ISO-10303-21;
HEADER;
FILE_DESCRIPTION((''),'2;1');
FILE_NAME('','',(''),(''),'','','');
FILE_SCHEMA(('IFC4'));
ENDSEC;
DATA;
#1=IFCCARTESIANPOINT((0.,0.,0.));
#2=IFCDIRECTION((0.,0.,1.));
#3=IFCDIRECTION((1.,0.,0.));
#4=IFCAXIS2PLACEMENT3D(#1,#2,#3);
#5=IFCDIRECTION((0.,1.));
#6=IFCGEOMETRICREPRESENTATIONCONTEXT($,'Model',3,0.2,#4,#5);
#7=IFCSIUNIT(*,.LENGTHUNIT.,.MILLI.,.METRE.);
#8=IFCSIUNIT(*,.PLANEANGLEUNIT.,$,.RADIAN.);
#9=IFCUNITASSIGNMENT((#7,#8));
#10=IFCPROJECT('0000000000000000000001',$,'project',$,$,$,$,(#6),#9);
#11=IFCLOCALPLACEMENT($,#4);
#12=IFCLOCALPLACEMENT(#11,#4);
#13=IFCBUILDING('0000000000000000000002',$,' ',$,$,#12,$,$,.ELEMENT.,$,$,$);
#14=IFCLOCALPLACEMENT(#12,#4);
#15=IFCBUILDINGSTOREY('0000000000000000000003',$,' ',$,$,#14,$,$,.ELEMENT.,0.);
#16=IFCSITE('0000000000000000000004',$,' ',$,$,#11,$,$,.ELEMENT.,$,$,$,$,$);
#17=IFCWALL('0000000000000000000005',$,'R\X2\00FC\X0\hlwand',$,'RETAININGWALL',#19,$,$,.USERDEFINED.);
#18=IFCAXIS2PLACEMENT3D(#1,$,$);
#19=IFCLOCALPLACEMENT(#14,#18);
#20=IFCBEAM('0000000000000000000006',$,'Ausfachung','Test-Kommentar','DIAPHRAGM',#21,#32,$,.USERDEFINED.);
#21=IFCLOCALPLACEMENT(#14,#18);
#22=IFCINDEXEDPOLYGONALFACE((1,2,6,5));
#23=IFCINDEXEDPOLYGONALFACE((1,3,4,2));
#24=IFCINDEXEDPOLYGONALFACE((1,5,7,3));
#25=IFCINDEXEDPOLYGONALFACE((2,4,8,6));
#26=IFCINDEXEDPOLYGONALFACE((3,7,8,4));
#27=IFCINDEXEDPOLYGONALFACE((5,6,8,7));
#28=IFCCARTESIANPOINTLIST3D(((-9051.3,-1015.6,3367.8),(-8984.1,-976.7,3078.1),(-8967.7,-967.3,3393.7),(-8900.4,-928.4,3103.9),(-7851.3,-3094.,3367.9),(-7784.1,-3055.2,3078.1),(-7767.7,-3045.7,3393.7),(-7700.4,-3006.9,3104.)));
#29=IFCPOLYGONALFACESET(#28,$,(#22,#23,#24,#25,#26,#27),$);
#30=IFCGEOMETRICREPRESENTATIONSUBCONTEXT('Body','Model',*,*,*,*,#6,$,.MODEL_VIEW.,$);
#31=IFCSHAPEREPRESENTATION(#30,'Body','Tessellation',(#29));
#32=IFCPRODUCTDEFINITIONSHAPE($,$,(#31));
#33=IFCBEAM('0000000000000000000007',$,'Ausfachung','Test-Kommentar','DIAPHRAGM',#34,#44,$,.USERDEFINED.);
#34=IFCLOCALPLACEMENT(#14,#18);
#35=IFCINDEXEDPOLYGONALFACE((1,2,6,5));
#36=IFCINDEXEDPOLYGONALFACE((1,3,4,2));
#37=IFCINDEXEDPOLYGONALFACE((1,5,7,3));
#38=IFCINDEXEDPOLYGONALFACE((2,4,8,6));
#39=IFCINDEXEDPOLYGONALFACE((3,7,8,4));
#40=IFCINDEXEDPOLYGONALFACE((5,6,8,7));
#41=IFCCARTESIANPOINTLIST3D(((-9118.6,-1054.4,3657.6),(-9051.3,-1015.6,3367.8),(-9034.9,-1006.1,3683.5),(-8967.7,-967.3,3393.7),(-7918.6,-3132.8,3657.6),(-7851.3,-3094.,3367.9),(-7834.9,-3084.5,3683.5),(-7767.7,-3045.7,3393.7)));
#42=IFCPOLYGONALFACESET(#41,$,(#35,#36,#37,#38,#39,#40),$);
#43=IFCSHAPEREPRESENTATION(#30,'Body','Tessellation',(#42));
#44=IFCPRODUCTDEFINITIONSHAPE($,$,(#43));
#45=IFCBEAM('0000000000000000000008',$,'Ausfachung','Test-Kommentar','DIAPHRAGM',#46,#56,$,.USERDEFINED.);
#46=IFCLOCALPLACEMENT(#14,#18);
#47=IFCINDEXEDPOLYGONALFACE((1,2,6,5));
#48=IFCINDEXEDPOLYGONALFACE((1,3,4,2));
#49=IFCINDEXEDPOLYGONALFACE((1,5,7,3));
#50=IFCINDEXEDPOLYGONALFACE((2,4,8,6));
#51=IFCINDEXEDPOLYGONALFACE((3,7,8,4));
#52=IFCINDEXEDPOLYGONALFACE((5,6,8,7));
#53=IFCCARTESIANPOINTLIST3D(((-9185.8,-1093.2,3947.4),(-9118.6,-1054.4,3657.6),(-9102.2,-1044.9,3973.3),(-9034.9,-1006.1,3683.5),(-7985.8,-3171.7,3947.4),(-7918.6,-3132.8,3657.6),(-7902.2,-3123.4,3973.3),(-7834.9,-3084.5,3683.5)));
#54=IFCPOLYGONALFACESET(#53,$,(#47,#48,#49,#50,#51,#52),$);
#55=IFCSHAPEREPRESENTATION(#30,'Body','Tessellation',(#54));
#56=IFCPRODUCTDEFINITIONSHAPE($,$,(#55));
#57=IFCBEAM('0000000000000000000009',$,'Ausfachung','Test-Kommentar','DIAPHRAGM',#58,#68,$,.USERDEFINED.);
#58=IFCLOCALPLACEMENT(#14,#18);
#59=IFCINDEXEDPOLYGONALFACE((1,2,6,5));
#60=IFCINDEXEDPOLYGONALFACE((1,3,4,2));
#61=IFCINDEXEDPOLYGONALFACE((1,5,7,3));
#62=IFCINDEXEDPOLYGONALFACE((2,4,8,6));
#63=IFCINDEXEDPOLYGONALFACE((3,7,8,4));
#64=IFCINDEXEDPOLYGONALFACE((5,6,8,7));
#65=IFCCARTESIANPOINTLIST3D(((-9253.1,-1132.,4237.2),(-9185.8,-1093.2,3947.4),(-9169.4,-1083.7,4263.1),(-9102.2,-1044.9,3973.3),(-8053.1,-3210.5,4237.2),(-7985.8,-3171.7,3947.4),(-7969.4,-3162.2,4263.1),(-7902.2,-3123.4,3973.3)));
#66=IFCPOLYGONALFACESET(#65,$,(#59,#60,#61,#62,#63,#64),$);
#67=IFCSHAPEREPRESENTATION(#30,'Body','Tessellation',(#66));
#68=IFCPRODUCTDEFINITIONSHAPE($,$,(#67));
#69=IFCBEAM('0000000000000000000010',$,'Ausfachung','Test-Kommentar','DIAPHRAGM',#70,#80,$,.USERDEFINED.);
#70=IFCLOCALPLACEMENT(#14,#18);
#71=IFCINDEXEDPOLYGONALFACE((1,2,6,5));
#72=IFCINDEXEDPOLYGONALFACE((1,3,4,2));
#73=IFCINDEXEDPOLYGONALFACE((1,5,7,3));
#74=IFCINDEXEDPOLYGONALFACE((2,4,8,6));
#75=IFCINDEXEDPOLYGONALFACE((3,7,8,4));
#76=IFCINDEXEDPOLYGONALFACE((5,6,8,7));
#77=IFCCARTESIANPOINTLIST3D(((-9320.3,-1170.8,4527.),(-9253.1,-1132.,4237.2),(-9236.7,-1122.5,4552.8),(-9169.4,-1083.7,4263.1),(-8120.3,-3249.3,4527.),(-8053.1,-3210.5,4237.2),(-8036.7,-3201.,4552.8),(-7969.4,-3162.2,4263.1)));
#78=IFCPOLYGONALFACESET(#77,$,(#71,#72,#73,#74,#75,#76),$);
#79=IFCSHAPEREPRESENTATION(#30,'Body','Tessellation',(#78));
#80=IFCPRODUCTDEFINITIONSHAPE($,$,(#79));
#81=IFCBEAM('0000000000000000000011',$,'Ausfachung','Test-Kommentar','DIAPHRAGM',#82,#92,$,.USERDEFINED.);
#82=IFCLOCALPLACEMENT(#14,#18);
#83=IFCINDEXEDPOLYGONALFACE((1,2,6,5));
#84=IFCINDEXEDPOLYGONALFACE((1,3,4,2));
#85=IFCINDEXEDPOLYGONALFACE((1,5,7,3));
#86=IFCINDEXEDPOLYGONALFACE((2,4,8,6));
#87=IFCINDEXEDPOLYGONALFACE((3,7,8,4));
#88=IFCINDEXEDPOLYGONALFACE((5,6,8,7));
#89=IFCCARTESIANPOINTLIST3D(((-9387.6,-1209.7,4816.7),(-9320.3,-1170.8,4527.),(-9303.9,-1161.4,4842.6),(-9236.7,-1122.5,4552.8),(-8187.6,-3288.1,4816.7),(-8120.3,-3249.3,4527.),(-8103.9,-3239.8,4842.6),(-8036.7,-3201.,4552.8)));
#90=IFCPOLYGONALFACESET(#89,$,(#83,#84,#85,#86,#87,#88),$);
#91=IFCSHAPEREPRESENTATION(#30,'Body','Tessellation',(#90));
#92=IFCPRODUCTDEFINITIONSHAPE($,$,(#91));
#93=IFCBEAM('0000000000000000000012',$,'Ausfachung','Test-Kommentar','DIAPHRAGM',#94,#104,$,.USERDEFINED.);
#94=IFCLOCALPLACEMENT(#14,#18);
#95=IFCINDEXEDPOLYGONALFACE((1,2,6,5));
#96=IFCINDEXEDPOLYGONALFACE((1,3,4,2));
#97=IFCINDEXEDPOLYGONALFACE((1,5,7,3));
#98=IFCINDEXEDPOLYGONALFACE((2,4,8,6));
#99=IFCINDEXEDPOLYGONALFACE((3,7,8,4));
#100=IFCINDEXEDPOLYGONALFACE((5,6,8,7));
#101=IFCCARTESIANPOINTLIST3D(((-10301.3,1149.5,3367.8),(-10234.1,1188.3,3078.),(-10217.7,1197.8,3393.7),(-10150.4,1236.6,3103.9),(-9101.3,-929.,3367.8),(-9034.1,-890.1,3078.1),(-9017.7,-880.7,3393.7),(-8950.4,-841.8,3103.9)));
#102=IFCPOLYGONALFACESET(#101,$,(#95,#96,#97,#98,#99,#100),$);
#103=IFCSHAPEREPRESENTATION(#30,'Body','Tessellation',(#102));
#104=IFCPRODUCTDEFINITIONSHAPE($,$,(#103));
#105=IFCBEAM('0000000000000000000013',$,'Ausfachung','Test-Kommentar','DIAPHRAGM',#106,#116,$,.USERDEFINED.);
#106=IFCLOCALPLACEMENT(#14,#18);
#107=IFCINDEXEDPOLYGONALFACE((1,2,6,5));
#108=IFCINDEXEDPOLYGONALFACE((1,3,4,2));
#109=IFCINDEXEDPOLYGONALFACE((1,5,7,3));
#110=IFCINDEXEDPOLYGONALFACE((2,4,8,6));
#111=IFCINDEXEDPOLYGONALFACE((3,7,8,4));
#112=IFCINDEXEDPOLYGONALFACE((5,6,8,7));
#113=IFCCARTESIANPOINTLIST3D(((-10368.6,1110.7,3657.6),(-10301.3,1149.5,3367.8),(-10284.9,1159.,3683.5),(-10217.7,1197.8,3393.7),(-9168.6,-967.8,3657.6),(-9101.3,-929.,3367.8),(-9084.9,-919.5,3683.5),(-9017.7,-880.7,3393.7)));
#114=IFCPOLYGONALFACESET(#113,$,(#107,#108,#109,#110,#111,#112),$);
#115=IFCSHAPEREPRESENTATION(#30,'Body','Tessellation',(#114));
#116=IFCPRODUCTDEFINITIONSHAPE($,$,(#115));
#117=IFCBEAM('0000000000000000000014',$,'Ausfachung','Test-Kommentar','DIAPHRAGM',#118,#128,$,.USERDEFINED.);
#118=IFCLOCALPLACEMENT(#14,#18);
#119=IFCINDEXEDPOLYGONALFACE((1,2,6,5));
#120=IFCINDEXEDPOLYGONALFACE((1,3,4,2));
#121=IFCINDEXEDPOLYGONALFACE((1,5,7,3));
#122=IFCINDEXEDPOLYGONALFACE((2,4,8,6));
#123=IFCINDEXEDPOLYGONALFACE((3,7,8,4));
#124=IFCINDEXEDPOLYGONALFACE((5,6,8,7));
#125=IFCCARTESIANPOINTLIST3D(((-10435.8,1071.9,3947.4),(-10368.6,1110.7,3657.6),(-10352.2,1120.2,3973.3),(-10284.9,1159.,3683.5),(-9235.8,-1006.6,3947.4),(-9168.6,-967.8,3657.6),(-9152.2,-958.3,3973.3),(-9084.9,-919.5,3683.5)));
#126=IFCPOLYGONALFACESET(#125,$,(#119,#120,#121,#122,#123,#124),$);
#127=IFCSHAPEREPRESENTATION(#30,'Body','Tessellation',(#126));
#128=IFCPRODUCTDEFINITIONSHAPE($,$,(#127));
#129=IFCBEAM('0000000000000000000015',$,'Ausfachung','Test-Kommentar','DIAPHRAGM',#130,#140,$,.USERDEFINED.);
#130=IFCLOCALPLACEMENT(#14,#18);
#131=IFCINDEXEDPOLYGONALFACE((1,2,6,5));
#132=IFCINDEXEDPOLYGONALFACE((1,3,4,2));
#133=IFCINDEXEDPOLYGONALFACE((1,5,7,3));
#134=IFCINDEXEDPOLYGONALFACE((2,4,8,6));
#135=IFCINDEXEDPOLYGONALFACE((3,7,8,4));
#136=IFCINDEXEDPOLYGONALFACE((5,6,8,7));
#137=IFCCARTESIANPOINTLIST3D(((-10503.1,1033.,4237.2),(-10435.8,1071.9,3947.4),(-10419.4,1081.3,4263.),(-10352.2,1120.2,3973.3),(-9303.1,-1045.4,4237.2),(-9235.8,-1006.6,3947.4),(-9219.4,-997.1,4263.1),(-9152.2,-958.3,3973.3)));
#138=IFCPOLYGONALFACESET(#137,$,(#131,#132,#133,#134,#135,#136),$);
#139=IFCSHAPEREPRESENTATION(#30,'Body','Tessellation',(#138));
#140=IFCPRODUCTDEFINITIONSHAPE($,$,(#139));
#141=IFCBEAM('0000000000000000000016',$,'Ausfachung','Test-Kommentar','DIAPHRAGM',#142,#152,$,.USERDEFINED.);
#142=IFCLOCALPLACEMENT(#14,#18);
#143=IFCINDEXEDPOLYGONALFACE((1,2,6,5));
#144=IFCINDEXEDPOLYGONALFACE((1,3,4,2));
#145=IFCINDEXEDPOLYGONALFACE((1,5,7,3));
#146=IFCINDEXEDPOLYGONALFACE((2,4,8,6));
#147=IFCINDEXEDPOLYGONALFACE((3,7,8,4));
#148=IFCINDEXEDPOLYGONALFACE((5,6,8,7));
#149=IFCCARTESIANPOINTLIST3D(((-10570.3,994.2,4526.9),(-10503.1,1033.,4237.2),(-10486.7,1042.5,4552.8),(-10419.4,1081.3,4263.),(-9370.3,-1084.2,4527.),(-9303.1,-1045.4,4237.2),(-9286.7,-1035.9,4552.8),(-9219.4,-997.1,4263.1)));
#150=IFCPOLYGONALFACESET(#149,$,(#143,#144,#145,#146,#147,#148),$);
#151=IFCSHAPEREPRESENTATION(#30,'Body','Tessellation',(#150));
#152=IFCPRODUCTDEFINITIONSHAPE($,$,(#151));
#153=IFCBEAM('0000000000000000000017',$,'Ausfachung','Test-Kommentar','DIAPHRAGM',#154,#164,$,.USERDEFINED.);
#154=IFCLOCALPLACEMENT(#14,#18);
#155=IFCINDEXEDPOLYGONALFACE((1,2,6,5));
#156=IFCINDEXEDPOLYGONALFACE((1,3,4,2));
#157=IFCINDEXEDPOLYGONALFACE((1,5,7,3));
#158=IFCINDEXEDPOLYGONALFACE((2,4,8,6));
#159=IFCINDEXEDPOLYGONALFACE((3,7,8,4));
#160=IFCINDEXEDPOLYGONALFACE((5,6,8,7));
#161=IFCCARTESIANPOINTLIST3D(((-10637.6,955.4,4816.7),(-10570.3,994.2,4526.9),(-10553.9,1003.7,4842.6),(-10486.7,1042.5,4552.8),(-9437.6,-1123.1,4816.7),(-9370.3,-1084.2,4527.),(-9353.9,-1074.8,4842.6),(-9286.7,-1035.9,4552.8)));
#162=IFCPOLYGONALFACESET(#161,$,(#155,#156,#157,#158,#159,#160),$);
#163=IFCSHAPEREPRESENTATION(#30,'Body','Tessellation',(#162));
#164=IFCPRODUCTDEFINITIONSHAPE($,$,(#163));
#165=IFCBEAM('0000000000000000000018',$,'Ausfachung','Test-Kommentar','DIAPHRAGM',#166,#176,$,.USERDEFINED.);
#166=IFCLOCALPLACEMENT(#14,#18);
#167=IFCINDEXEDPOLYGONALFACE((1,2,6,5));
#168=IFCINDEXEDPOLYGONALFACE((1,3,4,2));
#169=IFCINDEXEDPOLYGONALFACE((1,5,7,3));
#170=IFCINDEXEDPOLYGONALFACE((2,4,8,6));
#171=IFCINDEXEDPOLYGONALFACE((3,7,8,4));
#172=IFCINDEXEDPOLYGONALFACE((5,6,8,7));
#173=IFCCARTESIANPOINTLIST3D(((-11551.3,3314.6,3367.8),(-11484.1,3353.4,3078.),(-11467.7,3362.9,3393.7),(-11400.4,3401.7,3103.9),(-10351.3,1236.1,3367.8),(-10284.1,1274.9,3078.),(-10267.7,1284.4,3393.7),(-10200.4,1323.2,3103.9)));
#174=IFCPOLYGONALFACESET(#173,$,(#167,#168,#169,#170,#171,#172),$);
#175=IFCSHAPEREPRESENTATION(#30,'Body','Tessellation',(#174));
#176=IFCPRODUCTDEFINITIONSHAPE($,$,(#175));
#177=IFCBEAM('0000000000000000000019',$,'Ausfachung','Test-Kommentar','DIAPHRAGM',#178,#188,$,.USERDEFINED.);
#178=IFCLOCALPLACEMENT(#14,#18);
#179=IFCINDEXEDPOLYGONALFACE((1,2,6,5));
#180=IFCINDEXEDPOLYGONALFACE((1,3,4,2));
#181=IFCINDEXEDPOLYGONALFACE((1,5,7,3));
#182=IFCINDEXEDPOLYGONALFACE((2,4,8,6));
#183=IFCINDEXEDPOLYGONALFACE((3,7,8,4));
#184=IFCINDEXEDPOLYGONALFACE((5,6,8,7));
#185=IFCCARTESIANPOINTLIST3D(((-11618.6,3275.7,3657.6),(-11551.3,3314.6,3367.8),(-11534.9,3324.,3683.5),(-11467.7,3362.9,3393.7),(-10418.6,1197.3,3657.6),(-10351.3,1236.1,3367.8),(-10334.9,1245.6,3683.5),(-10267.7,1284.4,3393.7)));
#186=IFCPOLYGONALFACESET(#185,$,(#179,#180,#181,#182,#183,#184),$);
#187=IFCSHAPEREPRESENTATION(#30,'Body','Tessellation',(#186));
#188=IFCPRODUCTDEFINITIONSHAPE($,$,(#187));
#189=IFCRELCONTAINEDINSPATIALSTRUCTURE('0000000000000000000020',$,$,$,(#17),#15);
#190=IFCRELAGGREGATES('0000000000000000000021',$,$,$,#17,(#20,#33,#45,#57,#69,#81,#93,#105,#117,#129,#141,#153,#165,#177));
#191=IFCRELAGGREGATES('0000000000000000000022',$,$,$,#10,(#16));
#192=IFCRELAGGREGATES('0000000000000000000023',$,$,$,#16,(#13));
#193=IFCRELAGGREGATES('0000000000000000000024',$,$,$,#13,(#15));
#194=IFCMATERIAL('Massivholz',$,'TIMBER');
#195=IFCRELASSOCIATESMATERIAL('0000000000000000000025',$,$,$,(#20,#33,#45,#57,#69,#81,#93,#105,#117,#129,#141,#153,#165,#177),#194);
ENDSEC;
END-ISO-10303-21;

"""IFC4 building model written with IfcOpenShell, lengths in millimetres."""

from ifc_helpers import new_model, si_unit, direction, frame, origin_with_axes, place, context, subcontext, project, spatial, line, indexed_curve, outline, extrude, material, element, aggregate, save


model = new_model("IFC4")

# Units and contexts
model_context = context("Model", 3, precision=0.2, world=origin_with_axes(), true_north=direction((0.0, 1.0)))
body_context = subcontext(model_context, "Body", "Model", "MODEL_VIEW")
ifc_project = project(units=[si_unit("LENGTHUNIT", "METRE", prefix="MILLI"), si_unit("PLANEANGLEUNIT", "RADIAN")], contexts=[model_context])

# Site, building, storey
site_placement = place(None, origin_with_axes())
site = spatial("IfcSite", under=ifc_project, at=site_placement, Name=" ", CompositionType="ELEMENT")
building_placement = place(site_placement, origin_with_axes())
building = spatial("IfcBuilding", under=site, at=building_placement, Name=" ", CompositionType="ELEMENT")
storey_placement = place(building_placement, origin_with_axes())
storey = spatial("IfcBuildingStorey", under=building, at=storey_placement, Name=" ", CompositionType="ELEMENT", Elevation=0.0)

# Shared definitions
ifc_material_1 = material(Name="Massivholz", Category="TIMBER")

# Wall, beams
wall_1_placement = place(storey_placement, frame((-9848.6, 1445.5, 1545.5), z_axis=(-0.836516, -0.482964, -0.258819), x_axis=(0.499999, -0.866026, 0.000005)))
wall_1 = element("IfcWall", 1, at=wall_1_placement, inside=storey, Name="Rühlwand", ObjectType="RETAININGWALL", PredefinedType="USERDEFINED")
beam_1_placement = place(wall_1_placement, frame((2530.0, 1750.0, 0.0), z_axis=(0.0, 0.0, -1.0), x_axis=(1.0, 0.0, 0.0)))
beam_1 = element("IfcBeam", 2, at=beam_1_placement, material=ifc_material_1, Name="Ausfachung", Description="Test-Kommentar", ObjectType="DIAPHRAGM", PredefinedType="USERDEFINED", context=body_context, shape_type="SolidModel", body=[
    extrude(outline(indexed_curve([(-50.0, -150.0), (50.0, -150.0), (50.0, 150.0), (-50.0, 150.0)], segments=[line(1, 2, 3, 4, 1)])), frame((0.0, 0.0, 0.0), z_axis=(-1.0, 0.0, 0.0), x_axis=(0.0, 0.0, 1.0)), (0.0, 0.0, -1.0), 2400.0),
])
beam_2_placement = place(wall_1_placement, frame((2530.0, 2050.0, 0.0), z_axis=(0.0, 0.0, -1.0), x_axis=(1.0, 0.0, 0.0)))
beam_2 = element("IfcBeam", 3, at=beam_2_placement, material=ifc_material_1, Name="Ausfachung", Description="Test-Kommentar", ObjectType="DIAPHRAGM", PredefinedType="USERDEFINED", context=body_context, shape_type="SolidModel", body=[
    extrude(outline(indexed_curve([(-50.0, -150.0), (50.0, -150.0), (50.0, 150.0), (-50.0, 150.0)], segments=[line(1, 2, 3, 4, 1)])), frame((0.0, 0.0, 0.0), z_axis=(-1.0, 0.0, 0.0), x_axis=(0.0, 0.0, 1.0)), (0.0, 0.0, -1.0), 2400.0),
])
beam_3_placement = place(wall_1_placement, frame((2530.0, 2350.0, 0.0), z_axis=(0.0, 0.0, -1.0), x_axis=(1.0, 0.0, 0.0)))
beam_3 = element("IfcBeam", 4, at=beam_3_placement, material=ifc_material_1, Name="Ausfachung", Description="Test-Kommentar", ObjectType="DIAPHRAGM", PredefinedType="USERDEFINED", context=body_context, shape_type="SolidModel", body=[
    extrude(outline(indexed_curve([(-50.0, -150.0), (50.0, -150.0), (50.0, 150.0), (-50.0, 150.0)], segments=[line(1, 2, 3, 4, 1)])), frame((0.0, 0.0, 0.0), z_axis=(-1.0, 0.0, 0.0), x_axis=(0.0, 0.0, 1.0)), (0.0, 0.0, -1.0), 2400.0),
])
beam_4_placement = place(wall_1_placement, frame((2530.0, 2650.0, 0.0), z_axis=(0.0, 0.0, -1.0), x_axis=(1.0, 0.0, 0.0)))
beam_4 = element("IfcBeam", 5, at=beam_4_placement, material=ifc_material_1, Name="Ausfachung", Description="Test-Kommentar", ObjectType="DIAPHRAGM", PredefinedType="USERDEFINED", context=body_context, shape_type="SolidModel", body=[
    extrude(outline(indexed_curve([(-50.0, -150.0), (50.0, -150.0), (50.0, 150.0), (-50.0, 150.0)], segments=[line(1, 2, 3, 4, 1)])), frame((0.0, 0.0, 0.0), z_axis=(-1.0, 0.0, 0.0), x_axis=(0.0, 0.0, 1.0)), (0.0, 0.0, -1.0), 2400.0),
])
beam_5_placement = place(wall_1_placement, frame((2530.0, 2950.0, 0.0), z_axis=(0.0, 0.0, -1.0), x_axis=(1.0, 0.0, 0.0)))
beam_5 = element("IfcBeam", 6, at=beam_5_placement, material=ifc_material_1, Name="Ausfachung", Description="Test-Kommentar", ObjectType="DIAPHRAGM", PredefinedType="USERDEFINED", context=body_context, shape_type="SolidModel", body=[
    extrude(outline(indexed_curve([(-50.0, -150.0), (50.0, -150.0), (50.0, 150.0), (-50.0, 150.0)], segments=[line(1, 2, 3, 4, 1)])), frame((0.0, 0.0, 0.0), z_axis=(-1.0, 0.0, 0.0), x_axis=(0.0, 0.0, 1.0)), (0.0, 0.0, -1.0), 2400.0),
])
beam_6_placement = place(wall_1_placement, frame((2530.0, 3250.0, 0.0), z_axis=(0.0, 0.0, -1.0), x_axis=(1.0, 0.0, 0.0)))
beam_6 = element("IfcBeam", 7, at=beam_6_placement, material=ifc_material_1, Name="Ausfachung", Description="Test-Kommentar", ObjectType="DIAPHRAGM", PredefinedType="USERDEFINED", context=body_context, shape_type="SolidModel", body=[
    extrude(outline(indexed_curve([(-50.0, -150.0), (50.0, -150.0), (50.0, 150.0), (-50.0, 150.0)], segments=[line(1, 2, 3, 4, 1)])), frame((0.0, 0.0, 0.0), z_axis=(-1.0, 0.0, 0.0), x_axis=(0.0, 0.0, 1.0)), (0.0, 0.0, -1.0), 2400.0),
])
beam_7_placement = place(wall_1_placement, frame((30.0, 1750.0, 0.0), z_axis=(0.0, 0.0, -1.0), x_axis=(1.0, 0.0, 0.0)))
beam_7 = element("IfcBeam", 8, at=beam_7_placement, material=ifc_material_1, Name="Ausfachung", Description="Test-Kommentar", ObjectType="DIAPHRAGM", PredefinedType="USERDEFINED", context=body_context, shape_type="SolidModel", body=[
    extrude(outline(indexed_curve([(-50.0, -150.0), (50.0, -150.0), (50.0, 150.0), (-50.0, 150.0)], segments=[line(1, 2, 3, 4, 1)])), frame((0.0, 0.0, 0.0), z_axis=(-1.0, 0.0, 0.0), x_axis=(0.0, 0.0, 1.0)), (0.0, 0.0, -1.0), 2400.0),
])
beam_8_placement = place(wall_1_placement, frame((30.0, 2050.0, 0.0), z_axis=(0.0, 0.0, -1.0), x_axis=(1.0, 0.0, 0.0)))
beam_8 = element("IfcBeam", 9, at=beam_8_placement, material=ifc_material_1, Name="Ausfachung", Description="Test-Kommentar", ObjectType="DIAPHRAGM", PredefinedType="USERDEFINED", context=body_context, shape_type="SolidModel", body=[
    extrude(outline(indexed_curve([(-50.0, -150.0), (50.0, -150.0), (50.0, 150.0), (-50.0, 150.0)], segments=[line(1, 2, 3, 4, 1)])), frame((0.0, 0.0, 0.0), z_axis=(-1.0, 0.0, 0.0), x_axis=(0.0, 0.0, 1.0)), (0.0, 0.0, -1.0), 2400.0),
])
beam_9_placement = place(wall_1_placement, frame((30.0, 2350.0, 0.0), z_axis=(0.0, 0.0, -1.0), x_axis=(1.0, 0.0, 0.0)))
beam_9 = element("IfcBeam", 10, at=beam_9_placement, material=ifc_material_1, Name="Ausfachung", Description="Test-Kommentar", ObjectType="DIAPHRAGM", PredefinedType="USERDEFINED", context=body_context, shape_type="SolidModel", body=[
    extrude(outline(indexed_curve([(-50.0, -150.0), (50.0, -150.0), (50.0, 150.0), (-50.0, 150.0)], segments=[line(1, 2, 3, 4, 1)])), frame((0.0, 0.0, 0.0), z_axis=(-1.0, 0.0, 0.0), x_axis=(0.0, 0.0, 1.0)), (0.0, 0.0, -1.0), 2400.0),
])
beam_10_placement = place(wall_1_placement, frame((30.0, 2650.0, 0.0), z_axis=(0.0, 0.0, -1.0), x_axis=(1.0, 0.0, 0.0)))
beam_10 = element("IfcBeam", 11, at=beam_10_placement, material=ifc_material_1, Name="Ausfachung", Description="Test-Kommentar", ObjectType="DIAPHRAGM", PredefinedType="USERDEFINED", context=body_context, shape_type="SolidModel", body=[
    extrude(outline(indexed_curve([(-50.0, -150.0), (50.0, -150.0), (50.0, 150.0), (-50.0, 150.0)], segments=[line(1, 2, 3, 4, 1)])), frame((0.0, 0.0, 0.0), z_axis=(-1.0, 0.0, 0.0), x_axis=(0.0, 0.0, 1.0)), (0.0, 0.0, -1.0), 2400.0),
])
beam_11_placement = place(wall_1_placement, frame((30.0, 2950.0, 0.0), z_axis=(0.0, 0.0, -1.0), x_axis=(1.0, 0.0, 0.0)))
beam_11 = element("IfcBeam", 12, at=beam_11_placement, material=ifc_material_1, Name="Ausfachung", Description="Test-Kommentar", ObjectType="DIAPHRAGM", PredefinedType="USERDEFINED", context=body_context, shape_type="SolidModel", body=[
    extrude(outline(indexed_curve([(-50.0, -150.0), (50.0, -150.0), (50.0, 150.0), (-50.0, 150.0)], segments=[line(1, 2, 3, 4, 1)])), frame((0.0, 0.0, 0.0), z_axis=(-1.0, 0.0, 0.0), x_axis=(0.0, 0.0, 1.0)), (0.0, 0.0, -1.0), 2400.0),
])
beam_12_placement = place(wall_1_placement, frame((30.0, 3250.0, 0.0), z_axis=(0.0, 0.0, -1.0), x_axis=(1.0, 0.0, 0.0)))
beam_12 = element("IfcBeam", 13, at=beam_12_placement, material=ifc_material_1, Name="Ausfachung", Description="Test-Kommentar", ObjectType="DIAPHRAGM", PredefinedType="USERDEFINED", context=body_context, shape_type="SolidModel", body=[
    extrude(outline(indexed_curve([(-50.0, -150.0), (50.0, -150.0), (50.0, 150.0), (-50.0, 150.0)], segments=[line(1, 2, 3, 4, 1)])), frame((0.0, 0.0, 0.0), z_axis=(-1.0, 0.0, 0.0), x_axis=(0.0, 0.0, 1.0)), (0.0, 0.0, -1.0), 2400.0),
])
beam_13_placement = place(wall_1_placement, frame((-2470.0, 1750.0, 0.0), z_axis=(0.0, 0.0, -1.0), x_axis=(1.0, 0.0, 0.0)))
beam_13 = element("IfcBeam", 14, at=beam_13_placement, material=ifc_material_1, Name="Ausfachung", Description="Test-Kommentar", ObjectType="DIAPHRAGM", PredefinedType="USERDEFINED", context=body_context, shape_type="SolidModel", body=[
    extrude(outline(indexed_curve([(-50.0, -150.0), (50.0, -150.0), (50.0, 150.0), (-50.0, 150.0)], segments=[line(1, 2, 3, 4, 1)])), frame((0.0, 0.0, 0.0), z_axis=(-1.0, 0.0, 0.0), x_axis=(0.0, 0.0, 1.0)), (0.0, 0.0, -1.0), 2400.0),
])
beam_14_placement = place(wall_1_placement, frame((-2470.0, 2050.0, 0.0), z_axis=(0.0, 0.0, -1.0), x_axis=(1.0, 0.0, 0.0)))
beam_14 = element("IfcBeam", 15, at=beam_14_placement, material=ifc_material_1, Name="Ausfachung", Description="Test-Kommentar", ObjectType="DIAPHRAGM", PredefinedType="USERDEFINED", context=body_context, shape_type="SolidModel", body=[
    extrude(outline(indexed_curve([(-50.0, -150.0), (50.0, -150.0), (50.0, 150.0), (-50.0, 150.0)], segments=[line(1, 2, 3, 4, 1)])), frame((0.0, 0.0, 0.0), z_axis=(-1.0, 0.0, 0.0), x_axis=(0.0, 0.0, 1.0)), (0.0, 0.0, -1.0), 2400.0),
])
aggregate(wall_1, [beam_1, beam_2, beam_3, beam_4, beam_5, beam_6, beam_7, beam_8, beam_9, beam_10, beam_11, beam_12, beam_13, beam_14])

save(model, "model.ifc")
